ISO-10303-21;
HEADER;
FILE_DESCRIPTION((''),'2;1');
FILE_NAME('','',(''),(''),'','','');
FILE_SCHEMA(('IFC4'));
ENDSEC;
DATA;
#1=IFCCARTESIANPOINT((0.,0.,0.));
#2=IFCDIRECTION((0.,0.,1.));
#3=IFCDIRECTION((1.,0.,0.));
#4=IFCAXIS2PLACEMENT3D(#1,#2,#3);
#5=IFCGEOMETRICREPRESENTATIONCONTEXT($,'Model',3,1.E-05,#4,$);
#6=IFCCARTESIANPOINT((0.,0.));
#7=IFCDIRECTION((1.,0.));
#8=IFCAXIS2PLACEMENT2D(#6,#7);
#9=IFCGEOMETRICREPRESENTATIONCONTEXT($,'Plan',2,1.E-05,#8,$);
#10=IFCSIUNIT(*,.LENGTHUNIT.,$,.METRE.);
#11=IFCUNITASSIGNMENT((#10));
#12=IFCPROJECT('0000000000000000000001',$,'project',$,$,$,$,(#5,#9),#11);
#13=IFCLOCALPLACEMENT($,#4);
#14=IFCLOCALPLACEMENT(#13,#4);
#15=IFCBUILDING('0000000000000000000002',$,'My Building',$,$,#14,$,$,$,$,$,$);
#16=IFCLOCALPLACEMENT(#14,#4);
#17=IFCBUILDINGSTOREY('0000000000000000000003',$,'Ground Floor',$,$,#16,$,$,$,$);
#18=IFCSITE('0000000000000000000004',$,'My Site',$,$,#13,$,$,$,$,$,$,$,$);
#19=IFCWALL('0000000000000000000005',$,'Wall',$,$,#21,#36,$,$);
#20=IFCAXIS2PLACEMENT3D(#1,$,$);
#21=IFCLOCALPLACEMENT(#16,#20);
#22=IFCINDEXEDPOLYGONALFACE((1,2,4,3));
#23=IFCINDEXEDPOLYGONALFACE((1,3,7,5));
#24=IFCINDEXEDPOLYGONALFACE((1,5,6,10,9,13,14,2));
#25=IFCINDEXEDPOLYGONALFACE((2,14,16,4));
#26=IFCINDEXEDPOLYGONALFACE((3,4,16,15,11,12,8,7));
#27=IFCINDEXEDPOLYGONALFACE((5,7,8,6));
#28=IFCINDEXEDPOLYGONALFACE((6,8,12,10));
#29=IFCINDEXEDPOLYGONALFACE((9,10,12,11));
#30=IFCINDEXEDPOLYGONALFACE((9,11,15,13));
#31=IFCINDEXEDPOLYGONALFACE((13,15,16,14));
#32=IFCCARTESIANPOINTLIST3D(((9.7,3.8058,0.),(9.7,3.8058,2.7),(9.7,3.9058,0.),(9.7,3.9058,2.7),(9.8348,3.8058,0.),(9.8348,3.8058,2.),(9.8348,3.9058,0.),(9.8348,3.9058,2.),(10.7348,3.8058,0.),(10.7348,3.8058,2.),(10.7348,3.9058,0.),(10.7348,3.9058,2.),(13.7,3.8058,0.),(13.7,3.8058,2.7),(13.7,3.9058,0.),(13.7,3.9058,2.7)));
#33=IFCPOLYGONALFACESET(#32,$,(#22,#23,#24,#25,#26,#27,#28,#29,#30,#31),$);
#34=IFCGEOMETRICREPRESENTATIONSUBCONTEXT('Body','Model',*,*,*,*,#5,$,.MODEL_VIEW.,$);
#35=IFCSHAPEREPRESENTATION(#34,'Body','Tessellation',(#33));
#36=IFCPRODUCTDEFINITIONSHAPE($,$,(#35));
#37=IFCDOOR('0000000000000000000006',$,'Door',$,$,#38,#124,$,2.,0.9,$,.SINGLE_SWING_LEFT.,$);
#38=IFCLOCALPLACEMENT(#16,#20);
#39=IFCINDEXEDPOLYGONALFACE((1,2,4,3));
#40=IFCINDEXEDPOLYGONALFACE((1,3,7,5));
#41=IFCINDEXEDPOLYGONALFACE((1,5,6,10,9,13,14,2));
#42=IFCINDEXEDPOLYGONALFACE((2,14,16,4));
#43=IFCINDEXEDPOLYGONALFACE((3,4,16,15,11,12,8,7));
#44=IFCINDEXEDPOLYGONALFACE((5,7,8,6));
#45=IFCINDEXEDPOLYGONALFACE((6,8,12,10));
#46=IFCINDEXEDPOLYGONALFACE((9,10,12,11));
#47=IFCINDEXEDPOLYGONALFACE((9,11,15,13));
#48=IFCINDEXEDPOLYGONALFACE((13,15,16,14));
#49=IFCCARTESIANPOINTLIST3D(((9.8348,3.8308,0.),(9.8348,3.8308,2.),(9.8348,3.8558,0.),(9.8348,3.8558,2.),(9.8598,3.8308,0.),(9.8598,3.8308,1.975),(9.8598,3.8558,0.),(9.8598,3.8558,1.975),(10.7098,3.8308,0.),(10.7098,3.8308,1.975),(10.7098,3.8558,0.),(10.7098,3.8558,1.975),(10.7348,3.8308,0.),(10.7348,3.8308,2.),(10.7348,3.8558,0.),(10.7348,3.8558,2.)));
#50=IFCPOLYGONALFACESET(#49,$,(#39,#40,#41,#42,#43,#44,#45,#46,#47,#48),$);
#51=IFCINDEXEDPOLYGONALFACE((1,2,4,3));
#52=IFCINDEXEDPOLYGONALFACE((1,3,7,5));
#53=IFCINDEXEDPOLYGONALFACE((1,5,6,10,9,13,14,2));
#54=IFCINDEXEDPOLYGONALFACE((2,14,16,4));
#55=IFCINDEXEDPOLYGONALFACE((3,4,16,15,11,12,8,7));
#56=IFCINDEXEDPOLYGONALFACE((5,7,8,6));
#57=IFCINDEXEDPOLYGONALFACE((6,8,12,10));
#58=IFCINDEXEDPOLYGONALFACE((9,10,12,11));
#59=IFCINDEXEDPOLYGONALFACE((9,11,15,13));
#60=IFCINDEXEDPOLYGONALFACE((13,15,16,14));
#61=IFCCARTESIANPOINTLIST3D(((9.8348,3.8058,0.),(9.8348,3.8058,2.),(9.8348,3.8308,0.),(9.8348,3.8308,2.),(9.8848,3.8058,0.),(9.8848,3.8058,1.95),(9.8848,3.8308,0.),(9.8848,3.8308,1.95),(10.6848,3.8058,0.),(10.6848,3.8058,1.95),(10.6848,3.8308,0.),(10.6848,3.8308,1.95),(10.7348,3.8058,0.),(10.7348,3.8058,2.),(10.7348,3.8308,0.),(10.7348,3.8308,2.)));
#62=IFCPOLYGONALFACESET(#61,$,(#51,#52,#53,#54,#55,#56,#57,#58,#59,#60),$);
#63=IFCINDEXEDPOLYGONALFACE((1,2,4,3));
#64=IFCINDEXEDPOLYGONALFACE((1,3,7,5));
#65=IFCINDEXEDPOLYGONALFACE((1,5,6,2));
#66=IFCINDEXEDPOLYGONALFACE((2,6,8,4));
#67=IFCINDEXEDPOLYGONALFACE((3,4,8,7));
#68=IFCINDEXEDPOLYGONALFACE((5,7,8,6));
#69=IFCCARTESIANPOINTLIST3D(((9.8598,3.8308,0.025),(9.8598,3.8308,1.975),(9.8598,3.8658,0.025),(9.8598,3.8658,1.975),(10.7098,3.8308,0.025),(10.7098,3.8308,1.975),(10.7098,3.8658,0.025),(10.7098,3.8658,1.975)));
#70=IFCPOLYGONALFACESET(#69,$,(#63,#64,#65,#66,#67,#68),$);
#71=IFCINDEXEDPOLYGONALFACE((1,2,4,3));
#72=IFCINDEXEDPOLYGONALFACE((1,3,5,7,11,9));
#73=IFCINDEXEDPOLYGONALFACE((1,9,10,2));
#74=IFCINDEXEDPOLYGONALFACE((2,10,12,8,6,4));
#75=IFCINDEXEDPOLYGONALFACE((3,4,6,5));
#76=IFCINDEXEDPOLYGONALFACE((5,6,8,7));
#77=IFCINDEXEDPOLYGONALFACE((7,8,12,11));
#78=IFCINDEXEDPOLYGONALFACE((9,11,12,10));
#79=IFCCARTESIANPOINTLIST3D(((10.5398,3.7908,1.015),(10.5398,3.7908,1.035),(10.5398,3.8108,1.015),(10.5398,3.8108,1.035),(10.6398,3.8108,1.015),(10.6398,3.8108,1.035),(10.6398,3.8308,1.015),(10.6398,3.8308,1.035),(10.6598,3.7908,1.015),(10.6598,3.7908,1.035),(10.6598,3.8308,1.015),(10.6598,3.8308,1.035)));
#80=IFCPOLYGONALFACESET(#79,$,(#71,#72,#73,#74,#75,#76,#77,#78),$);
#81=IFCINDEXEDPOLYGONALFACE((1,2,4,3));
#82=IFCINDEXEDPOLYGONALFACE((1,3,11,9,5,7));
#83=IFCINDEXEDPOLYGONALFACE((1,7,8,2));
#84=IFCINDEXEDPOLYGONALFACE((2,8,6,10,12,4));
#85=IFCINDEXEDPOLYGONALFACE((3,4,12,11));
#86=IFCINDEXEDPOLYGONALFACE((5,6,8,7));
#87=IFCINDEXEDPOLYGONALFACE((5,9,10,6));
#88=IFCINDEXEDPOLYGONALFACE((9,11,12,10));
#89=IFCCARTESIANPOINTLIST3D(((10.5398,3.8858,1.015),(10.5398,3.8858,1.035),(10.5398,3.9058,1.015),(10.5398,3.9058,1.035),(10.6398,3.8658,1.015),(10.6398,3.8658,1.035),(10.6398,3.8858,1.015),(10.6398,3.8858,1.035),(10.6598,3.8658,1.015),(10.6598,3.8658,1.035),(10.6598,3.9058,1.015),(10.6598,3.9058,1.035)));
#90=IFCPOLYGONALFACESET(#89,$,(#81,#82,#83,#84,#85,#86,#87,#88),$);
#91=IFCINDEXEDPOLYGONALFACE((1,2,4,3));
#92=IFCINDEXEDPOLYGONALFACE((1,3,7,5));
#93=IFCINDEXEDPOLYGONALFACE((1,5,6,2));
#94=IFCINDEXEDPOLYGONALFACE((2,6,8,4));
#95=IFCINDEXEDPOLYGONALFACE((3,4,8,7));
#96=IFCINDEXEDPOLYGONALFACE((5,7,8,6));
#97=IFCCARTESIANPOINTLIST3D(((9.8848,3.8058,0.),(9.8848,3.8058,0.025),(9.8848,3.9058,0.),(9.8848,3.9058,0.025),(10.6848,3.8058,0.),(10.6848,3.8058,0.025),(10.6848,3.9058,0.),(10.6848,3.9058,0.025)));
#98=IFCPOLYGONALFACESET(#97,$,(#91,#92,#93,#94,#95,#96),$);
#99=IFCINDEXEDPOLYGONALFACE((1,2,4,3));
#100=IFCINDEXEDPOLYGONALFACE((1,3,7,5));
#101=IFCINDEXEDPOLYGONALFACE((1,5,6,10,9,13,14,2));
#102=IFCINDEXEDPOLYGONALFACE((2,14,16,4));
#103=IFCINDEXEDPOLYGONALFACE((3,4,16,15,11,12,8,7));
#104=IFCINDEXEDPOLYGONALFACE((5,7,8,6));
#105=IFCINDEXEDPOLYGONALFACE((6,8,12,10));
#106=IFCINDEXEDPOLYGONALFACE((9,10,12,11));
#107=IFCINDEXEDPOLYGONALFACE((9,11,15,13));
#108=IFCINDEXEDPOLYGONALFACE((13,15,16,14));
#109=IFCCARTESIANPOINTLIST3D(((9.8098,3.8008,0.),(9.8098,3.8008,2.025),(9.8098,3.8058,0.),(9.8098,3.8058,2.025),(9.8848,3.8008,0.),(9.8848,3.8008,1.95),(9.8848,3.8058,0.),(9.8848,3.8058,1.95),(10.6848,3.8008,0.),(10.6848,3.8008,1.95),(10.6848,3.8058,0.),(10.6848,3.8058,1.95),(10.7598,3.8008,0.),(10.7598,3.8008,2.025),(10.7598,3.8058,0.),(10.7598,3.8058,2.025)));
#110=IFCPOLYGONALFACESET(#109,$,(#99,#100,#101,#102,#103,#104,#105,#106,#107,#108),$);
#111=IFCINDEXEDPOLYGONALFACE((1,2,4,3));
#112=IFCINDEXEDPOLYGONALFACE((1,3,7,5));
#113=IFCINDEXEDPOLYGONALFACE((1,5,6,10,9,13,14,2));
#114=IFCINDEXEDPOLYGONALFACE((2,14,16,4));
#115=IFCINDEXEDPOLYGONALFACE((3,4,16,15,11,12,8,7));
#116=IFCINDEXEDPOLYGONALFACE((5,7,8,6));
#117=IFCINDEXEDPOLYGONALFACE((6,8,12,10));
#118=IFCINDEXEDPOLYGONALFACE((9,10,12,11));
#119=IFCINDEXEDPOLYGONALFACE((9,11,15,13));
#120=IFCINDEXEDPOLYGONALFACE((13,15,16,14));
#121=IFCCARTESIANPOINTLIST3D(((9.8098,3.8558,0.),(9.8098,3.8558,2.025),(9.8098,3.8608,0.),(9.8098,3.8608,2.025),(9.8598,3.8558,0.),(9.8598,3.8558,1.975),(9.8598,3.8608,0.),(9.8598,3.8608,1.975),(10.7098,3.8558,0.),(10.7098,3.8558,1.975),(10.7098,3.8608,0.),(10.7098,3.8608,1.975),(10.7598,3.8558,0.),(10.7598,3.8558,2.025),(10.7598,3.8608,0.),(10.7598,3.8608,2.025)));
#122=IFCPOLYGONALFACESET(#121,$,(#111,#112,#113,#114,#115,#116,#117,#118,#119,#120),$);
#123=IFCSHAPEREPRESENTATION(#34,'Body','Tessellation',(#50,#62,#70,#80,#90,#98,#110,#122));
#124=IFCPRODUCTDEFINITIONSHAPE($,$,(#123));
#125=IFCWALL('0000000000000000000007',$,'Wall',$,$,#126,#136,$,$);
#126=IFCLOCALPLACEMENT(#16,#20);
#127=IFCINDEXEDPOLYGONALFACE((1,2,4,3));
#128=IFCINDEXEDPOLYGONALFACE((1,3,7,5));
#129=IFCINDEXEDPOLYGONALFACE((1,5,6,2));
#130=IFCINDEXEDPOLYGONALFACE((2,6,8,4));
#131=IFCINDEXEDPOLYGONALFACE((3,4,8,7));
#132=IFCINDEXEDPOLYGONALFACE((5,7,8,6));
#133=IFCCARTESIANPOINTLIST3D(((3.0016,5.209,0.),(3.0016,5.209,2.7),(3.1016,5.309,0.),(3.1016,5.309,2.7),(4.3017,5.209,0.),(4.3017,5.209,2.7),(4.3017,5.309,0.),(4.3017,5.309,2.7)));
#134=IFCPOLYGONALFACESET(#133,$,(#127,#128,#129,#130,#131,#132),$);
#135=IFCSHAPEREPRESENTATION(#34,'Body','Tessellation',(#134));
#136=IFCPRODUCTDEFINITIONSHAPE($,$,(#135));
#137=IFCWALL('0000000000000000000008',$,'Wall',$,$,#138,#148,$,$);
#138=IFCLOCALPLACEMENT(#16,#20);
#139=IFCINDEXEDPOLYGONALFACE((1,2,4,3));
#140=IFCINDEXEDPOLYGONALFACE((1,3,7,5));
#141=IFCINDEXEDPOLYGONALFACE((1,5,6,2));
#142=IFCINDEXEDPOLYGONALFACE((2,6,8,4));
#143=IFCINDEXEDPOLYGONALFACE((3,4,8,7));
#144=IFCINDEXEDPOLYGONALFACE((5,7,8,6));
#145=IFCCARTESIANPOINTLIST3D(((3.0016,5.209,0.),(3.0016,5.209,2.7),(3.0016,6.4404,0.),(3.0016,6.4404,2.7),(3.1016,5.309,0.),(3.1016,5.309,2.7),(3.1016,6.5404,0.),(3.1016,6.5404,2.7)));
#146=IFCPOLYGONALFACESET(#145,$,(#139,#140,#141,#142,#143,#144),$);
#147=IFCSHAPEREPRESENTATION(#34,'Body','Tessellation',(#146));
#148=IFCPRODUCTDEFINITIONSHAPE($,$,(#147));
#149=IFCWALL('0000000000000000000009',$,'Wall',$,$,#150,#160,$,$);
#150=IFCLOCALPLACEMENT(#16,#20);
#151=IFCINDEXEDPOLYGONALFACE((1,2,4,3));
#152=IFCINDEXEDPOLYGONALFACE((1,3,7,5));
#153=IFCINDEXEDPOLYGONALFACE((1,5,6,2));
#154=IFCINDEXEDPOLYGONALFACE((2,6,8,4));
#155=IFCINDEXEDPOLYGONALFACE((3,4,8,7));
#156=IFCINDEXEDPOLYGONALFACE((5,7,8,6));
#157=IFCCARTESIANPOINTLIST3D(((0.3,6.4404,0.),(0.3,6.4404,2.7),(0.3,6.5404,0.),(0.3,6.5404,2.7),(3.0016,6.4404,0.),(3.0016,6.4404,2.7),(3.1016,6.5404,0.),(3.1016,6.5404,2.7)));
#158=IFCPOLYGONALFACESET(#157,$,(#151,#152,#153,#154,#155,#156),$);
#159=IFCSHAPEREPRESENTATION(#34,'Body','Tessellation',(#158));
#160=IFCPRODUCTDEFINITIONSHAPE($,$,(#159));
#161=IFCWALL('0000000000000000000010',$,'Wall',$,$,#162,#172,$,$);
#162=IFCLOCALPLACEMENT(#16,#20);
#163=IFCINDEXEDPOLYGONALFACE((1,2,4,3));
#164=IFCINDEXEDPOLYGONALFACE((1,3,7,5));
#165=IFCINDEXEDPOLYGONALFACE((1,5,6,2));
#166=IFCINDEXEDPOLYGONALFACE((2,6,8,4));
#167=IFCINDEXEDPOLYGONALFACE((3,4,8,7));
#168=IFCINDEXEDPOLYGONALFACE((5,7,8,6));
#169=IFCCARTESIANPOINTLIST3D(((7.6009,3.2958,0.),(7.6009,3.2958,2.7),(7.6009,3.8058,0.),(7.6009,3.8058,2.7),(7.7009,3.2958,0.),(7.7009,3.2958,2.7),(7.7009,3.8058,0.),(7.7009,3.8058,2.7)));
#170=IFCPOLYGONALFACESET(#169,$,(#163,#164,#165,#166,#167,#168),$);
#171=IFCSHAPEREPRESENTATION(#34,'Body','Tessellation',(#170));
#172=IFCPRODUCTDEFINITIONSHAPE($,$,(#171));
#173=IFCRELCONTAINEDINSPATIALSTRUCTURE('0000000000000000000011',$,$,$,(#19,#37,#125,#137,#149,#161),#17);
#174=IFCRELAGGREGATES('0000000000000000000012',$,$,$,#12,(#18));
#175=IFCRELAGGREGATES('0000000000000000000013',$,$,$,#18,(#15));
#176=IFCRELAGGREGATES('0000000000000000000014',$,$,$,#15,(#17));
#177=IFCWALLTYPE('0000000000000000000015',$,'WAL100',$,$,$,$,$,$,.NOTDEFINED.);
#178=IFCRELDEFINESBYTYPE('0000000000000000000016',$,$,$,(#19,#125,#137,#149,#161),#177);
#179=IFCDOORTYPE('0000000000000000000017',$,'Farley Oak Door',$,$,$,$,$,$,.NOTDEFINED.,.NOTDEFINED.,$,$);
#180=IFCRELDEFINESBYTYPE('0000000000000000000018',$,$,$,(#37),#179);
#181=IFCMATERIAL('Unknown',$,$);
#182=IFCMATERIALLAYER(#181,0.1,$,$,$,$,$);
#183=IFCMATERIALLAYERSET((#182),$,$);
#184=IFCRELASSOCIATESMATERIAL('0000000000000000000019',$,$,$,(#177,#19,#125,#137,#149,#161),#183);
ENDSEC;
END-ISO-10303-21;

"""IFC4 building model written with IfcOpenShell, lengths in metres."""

from ifc_helpers import new_model, entity, si_unit, frame, origin_with_axes, origin_2d_with_axis, place, context, subcontext, project, spatial, line, indexed_curve, outline, extrude, shape, source, transform, mapped, material, layer, layer_set, layer_usage, type_object, type_shapes, element, fill, save


model = new_model("IFC4")

# Units and contexts
model_context = context("Model", 3, precision=1e-05, world=origin_with_axes())
plan_context = context("Plan", 2, precision=1e-05, world=origin_2d_with_axis())
body_context_1 = subcontext(model_context, "Body", "Model", "MODEL_VIEW")
body_context_2 = subcontext(plan_context, "Body", "Plan", "PLAN_VIEW")
ifc_project = project(units=[si_unit("LENGTHUNIT", "METRE")], contexts=[model_context, plan_context])

# Site, building, storey
site_placement = place(None, origin_with_axes())
site = spatial("IfcSite", under=ifc_project, at=site_placement, Name="My Site")
building_placement = place(site_placement, origin_with_axes())
building = spatial("IfcBuilding", under=site, at=building_placement, Name="My Building")
storey_placement = place(building_placement, origin_with_axes())
storey = spatial("IfcBuildingStorey", under=building, at=storey_placement, Name="Ground Floor")

# Shared definitions
ifc_material = material(Name="Unknown")

# Shared definitions
ifc_layer_1 = layer(ifc_material, 0.1)
ifc_layer_set_1 = layer_set([ifc_layer_1])
wall_type = type_object("IfcWallType", Name="WAL100", PredefinedType="NOTDEFINED", material=ifc_layer_set_1)
shared_shape_1 = source(origin_with_axes(), body_context_1, "Body", "SweptSolid", [
    extrude(outline(indexed_curve([(0.0, 0.0), (0.9, 0.0), (0.9, 2.0), (0.0, 2.0)], segments=[line(1, 2, 3, 4, 1)])), frame((0.0, -0.6, 0.0), z_axis=(0.0, -1.0, 0.0), x_axis=(1.0, 0.0, 0.0)), (0.0, 0.0, -1.0), 1.2),
])
door_type_1 = type_object("IfcDoorType", Name="Farley Oak Door", OperationType="NOTDEFINED", PredefinedType="NOTDEFINED")
shared_shape_2 = source(origin_with_axes(), body_context_1, "Body", "SweptSolid", [
    extrude(outline(indexed_curve([(0.0, 0.0), (0.0, 2.0), (0.9, 2.0), (0.9, 0.0), (0.875, 0.0), (0.875, 1.975), (0.025, 1.975), (0.025, 0.0)], segments=[line(1, 2, 3, 4, 5, 6, 7, 8, 1)])), frame((0.0, 0.025, 0.0), z_axis=(0.0, -1.0, 0.0), x_axis=(1.0, 0.0, 0.0)), (0.0, 0.0, -1.0), 0.025),
    extrude(outline(indexed_curve([(0.0, 0.0), (0.0, 2.0), (0.9, 2.0), (0.9, 0.0), (0.85, 0.0), (0.85, 1.95), (0.05, 1.95), (0.05, 0.0)], segments=[line(1, 2, 3, 4, 5, 6, 7, 8, 1)])), frame((0.0, 0.0, 0.0), z_axis=(0.0, -1.0, 0.0), x_axis=(1.0, 0.0, 0.0)), (0.0, 0.0, -1.0), 0.025),
    extrude(outline(indexed_curve([(0.0, 0.0), (0.85, 0.0), (0.85, 0.035), (0.0, 0.035)], segments=[line(1, 2, 3, 4, 1)])), frame((0.025, 0.025, 0.025), z_axis=(0.0, 0.0, 1.0), x_axis=(1.0, 0.0, 0.0)), (0.0, 0.0, 1.0), 1.95),
    extrude(outline(indexed_curve([(0.0, 0.0), (0.0, -0.04), (-0.12, -0.04), (-0.12, -0.02), (-0.02, -0.02), (-0.02, 0.0)], segments=[line(1, 2, 3, 4, 5, 6, 1)])), frame((0.825, 0.025, 1.015), z_axis=(0.0, 0.0, 1.0), x_axis=(1.0, 0.0, 0.0)), (0.0, 0.0, 1.0), 0.02),
    extrude(outline(indexed_curve([(0.0, 0.0), (0.0, 0.04), (-0.12, 0.04), (-0.12, 0.02), (-0.02, 0.02), (-0.02, 0.0)], segments=[line(1, 2, 3, 4, 5, 6, 1)])), frame((0.825, 0.06, 1.015), z_axis=(0.0, 0.0, 1.0), x_axis=(1.0, 0.0, 0.0)), (0.0, 0.0, 1.0), 0.02),
    extrude(outline(indexed_curve([(0.0, 0.0), (0.8, 0.0), (0.8, 0.1), (0.0, 0.1)], segments=[line(1, 2, 3, 4, 1)])), frame((0.05, 0.0, 0.0), z_axis=(0.0, 0.0, 1.0), x_axis=(1.0, 0.0, 0.0)), (0.0, 0.0, 1.0), 0.025),
    extrude(outline(indexed_curve([(0.0, 0.0), (0.0, 2.025), (0.95, 2.025), (0.95, 0.0), (0.875, 0.0), (0.875, 1.95), (0.075, 1.95), (0.075, 0.0)], segments=[line(1, 2, 3, 4, 5, 6, 7, 8, 1)])), frame((-0.025, -0.005, 0.0), z_axis=(0.0, -1.0, 0.0), x_axis=(1.0, 0.0, 0.0)), (0.0, 0.0, -1.0), 0.005),
    extrude(outline(indexed_curve([(0.0, 0.0), (0.0, 2.025), (0.95, 2.025), (0.95, 0.0), (0.9, 0.0), (0.9, 1.975), (0.05, 1.975), (0.05, 0.0)], segments=[line(1, 2, 3, 4, 5, 6, 7, 8, 1)])), frame((-0.025, 0.05, 0.0), z_axis=(0.0, -1.0, 0.0), x_axis=(1.0, 0.0, 0.0)), (0.0, 0.0, -1.0), 0.005),
])
shared_shape_3 = source(origin_with_axes(), body_context_2, "Body", "Curve2D", [
    entity("IfcIndexedPolyCurve", entity("IfcCartesianPointList2D", [[0.0, 0.0], [0.0, 0.05], [0.025, 0.05], [0.025, 0.025], [0.05, 0.025], [0.05, 0.0]]), [entity("IfcLineIndex", [1, 2, 3, 4, 5, 6, 1])]),
    entity("IfcIndexedPolyCurve", entity("IfcCartesianPointList2D", [[0.9, 0.0], [0.9, 0.05], [0.875, 0.05], [0.875, 0.025], [0.85, 0.025], [0.85, 0.0]]), [entity("IfcLineIndex", [1, 2, 3, 4, 5, 6, 1])]),
    entity("IfcTrimmedCurve", entity("IfcEllipse", entity("IfcAxis2Placement2D", entity("IfcCartesianPoint", [0.06, 0.05]), entity("IfcDirection", [1.0, 0.0])), 0.815, 0.85), [entity("IfcCartesianPoint", [0.875, 0.05])], [entity("IfcCartesianPoint", [0.06, 0.9])], True, "CARTESIAN"),
    entity("IfcIndexedPolyCurve", entity("IfcCartesianPointList2D", [[0.025, 0.05], [0.06, 0.05], [0.06, 0.9], [0.025, 0.9]]), [entity("IfcLineIndex", [1, 2, 3, 4, 1])]),
])
type_shapes(door_type_1, [shared_shape_2, shared_shape_3])

# Wall, opening, door
ifc_layer_usage_1 = layer_usage(ifc_layer_set_1, "AXIS2", "POSITIVE", 0.0)
wall_1_placement = place(storey_placement, frame((9.7, 3.8058, 0.0), z_axis=(0.0, 0.0, 1.0), x_axis=(1.0, 0.0, 0.0)))
wall_1 = element("IfcWall", 1, at=wall_1_placement, inside=storey, type_object=wall_type, material=ifc_layer_usage_1, Name="Wall", context=body_context_1, shape_type="SweptSolid", body=[
    extrude(outline(indexed_curve([(0.0, 0.0), (0.0, 0.1), (4.0, 0.1), (4.0, 0.0)], segments=[line(1, 2, 3, 4, 1)])), origin_with_axes(), (0.0, 0.0, 1.0), 2.7),
])
opening_1_placement = place(wall_1_placement, frame((0.1348, 0.0, 0.0), z_axis=(0.0, 0.0, 1.0), x_axis=(1.0, 0.0, 0.0)))
opening_1 = element("IfcOpeningElement", 2, at=opening_1_placement, cuts=wall_1, PredefinedType="OPENING", context=body_context_1, shape_type="MappedRepresentation", body=[
    mapped(shared_shape_1, transform((0.0, 0.0, 0.0), x_axis=(1.0, 0.0, 0.0), y_axis=(0.0, 1.0, 0.0), z_axis=(0.0, 0.0, 1.0), scale=1.0)),
])
door_1_placement = place(opening_1_placement, frame((0.0, 0.0, 0.0), z_axis=(0.0, 0.0, 1.0), x_axis=(1.0, 0.0, 0.0)))
door_1 = element("IfcDoor", 3, at=door_1_placement, inside=storey, type_object=door_type_1, Name="Door", OperationType="SINGLE_SWING_LEFT", OverallHeight=2.0, OverallWidth=0.9, shapes=[
    shape(body_context_1, "Body", "MappedRepresentation", [mapped(shared_shape_2, transform((0.0, 0.0, 0.0), x_axis=(1.0, 0.0, 0.0), y_axis=(0.0, 1.0, 0.0), z_axis=(0.0, 0.0, 1.0), scale=1.0))]),
    shape(body_context_2, "Body", "MappedRepresentation", [mapped(shared_shape_3, transform((0.0, 0.0, 0.0), x_axis=(1.0, 0.0, 0.0), y_axis=(0.0, 1.0, 0.0), z_axis=(0.0, 0.0, 1.0), scale=1.0))]),
])
fill(opening_1, door_1)

# Walls
ifc_layer_usage_2 = layer_usage(ifc_layer_set_1, "AXIS2", "POSITIVE", 0.0)
wall_2_placement = place(storey_placement, frame((4.3017, 5.309, 0.0), z_axis=(0.0, 0.0, 1.0), x_axis=(-1.0, 0.0, 0.0)))
element("IfcWall", 4, at=wall_2_placement, inside=storey, type_object=wall_type, material=ifc_layer_usage_2, Name="Wall", context=body_context_1, shape_type="SweptSolid", body=[
    extrude(outline(indexed_curve([(0.0, 0.0), (0.0, 0.1), (1.3001, 0.1), (1.2001, 0.0)], segments=[line(1, 2, 3, 4, 1)])), origin_with_axes(), (0.0, 0.0, 1.0), 2.7),
])
ifc_layer_usage_3 = layer_usage(ifc_layer_set_1, "AXIS2", "POSITIVE", 0.0)
wall_3_placement = place(storey_placement, frame((3.1016, 5.309, 0.0), z_axis=(0.0, 0.0, 1.0), x_axis=(0.0, 1.0, 0.0)))
element("IfcWall", 5, at=wall_3_placement, inside=storey, type_object=wall_type, material=ifc_layer_usage_3, Name="Wall", context=body_context_1, shape_type="SweptSolid", body=[
    extrude(outline(indexed_curve([(0.0, 0.0), (-0.1, 0.1), (1.1314, 0.1), (1.2314, 0.0)], segments=[line(1, 2, 3, 4, 1)])), origin_with_axes(), (0.0, 0.0, 1.0), 2.7),
])
ifc_layer_usage_4 = layer_usage(ifc_layer_set_1, "AXIS2", "POSITIVE", 0.0)
wall_4_placement = place(storey_placement, frame((0.3, 6.4404, 0.0), z_axis=(0.0, 0.0, 1.0), x_axis=(1.0, 0.0, 0.0)))
element("IfcWall", 6, at=wall_4_placement, inside=storey, type_object=wall_type, material=ifc_layer_usage_4, Name="Wall", context=body_context_1, shape_type="SweptSolid", body=[
    extrude(outline(indexed_curve([(0.0, 0.0), (0.0, 0.1), (2.8016, 0.1), (2.7016, 0.0)], segments=[line(1, 2, 3, 4, 1)])), origin_with_axes(), (0.0, 0.0, 1.0), 2.7),
])
ifc_layer_usage_5 = layer_usage(ifc_layer_set_1, "AXIS2", "POSITIVE", 0.0)
wall_5_placement = place(storey_placement, frame((7.6009, 3.8058, 0.0), z_axis=(0.0, 0.0, 1.0), x_axis=(0.0, -1.0, 0.0)))
element("IfcWall", 7, at=wall_5_placement, inside=storey, type_object=wall_type, material=ifc_layer_usage_5, Name="Wall", context=body_context_1, shape_type="SweptSolid", body=[
    extrude(outline(indexed_curve([(0.0, 0.0), (0.0, 0.1), (0.51, 0.1), (0.51, 0.0)], segments=[line(1, 2, 3, 4, 1)])), origin_with_axes(), (0.0, 0.0, 1.0), 2.7),
])

save(model, "model.ifc")
